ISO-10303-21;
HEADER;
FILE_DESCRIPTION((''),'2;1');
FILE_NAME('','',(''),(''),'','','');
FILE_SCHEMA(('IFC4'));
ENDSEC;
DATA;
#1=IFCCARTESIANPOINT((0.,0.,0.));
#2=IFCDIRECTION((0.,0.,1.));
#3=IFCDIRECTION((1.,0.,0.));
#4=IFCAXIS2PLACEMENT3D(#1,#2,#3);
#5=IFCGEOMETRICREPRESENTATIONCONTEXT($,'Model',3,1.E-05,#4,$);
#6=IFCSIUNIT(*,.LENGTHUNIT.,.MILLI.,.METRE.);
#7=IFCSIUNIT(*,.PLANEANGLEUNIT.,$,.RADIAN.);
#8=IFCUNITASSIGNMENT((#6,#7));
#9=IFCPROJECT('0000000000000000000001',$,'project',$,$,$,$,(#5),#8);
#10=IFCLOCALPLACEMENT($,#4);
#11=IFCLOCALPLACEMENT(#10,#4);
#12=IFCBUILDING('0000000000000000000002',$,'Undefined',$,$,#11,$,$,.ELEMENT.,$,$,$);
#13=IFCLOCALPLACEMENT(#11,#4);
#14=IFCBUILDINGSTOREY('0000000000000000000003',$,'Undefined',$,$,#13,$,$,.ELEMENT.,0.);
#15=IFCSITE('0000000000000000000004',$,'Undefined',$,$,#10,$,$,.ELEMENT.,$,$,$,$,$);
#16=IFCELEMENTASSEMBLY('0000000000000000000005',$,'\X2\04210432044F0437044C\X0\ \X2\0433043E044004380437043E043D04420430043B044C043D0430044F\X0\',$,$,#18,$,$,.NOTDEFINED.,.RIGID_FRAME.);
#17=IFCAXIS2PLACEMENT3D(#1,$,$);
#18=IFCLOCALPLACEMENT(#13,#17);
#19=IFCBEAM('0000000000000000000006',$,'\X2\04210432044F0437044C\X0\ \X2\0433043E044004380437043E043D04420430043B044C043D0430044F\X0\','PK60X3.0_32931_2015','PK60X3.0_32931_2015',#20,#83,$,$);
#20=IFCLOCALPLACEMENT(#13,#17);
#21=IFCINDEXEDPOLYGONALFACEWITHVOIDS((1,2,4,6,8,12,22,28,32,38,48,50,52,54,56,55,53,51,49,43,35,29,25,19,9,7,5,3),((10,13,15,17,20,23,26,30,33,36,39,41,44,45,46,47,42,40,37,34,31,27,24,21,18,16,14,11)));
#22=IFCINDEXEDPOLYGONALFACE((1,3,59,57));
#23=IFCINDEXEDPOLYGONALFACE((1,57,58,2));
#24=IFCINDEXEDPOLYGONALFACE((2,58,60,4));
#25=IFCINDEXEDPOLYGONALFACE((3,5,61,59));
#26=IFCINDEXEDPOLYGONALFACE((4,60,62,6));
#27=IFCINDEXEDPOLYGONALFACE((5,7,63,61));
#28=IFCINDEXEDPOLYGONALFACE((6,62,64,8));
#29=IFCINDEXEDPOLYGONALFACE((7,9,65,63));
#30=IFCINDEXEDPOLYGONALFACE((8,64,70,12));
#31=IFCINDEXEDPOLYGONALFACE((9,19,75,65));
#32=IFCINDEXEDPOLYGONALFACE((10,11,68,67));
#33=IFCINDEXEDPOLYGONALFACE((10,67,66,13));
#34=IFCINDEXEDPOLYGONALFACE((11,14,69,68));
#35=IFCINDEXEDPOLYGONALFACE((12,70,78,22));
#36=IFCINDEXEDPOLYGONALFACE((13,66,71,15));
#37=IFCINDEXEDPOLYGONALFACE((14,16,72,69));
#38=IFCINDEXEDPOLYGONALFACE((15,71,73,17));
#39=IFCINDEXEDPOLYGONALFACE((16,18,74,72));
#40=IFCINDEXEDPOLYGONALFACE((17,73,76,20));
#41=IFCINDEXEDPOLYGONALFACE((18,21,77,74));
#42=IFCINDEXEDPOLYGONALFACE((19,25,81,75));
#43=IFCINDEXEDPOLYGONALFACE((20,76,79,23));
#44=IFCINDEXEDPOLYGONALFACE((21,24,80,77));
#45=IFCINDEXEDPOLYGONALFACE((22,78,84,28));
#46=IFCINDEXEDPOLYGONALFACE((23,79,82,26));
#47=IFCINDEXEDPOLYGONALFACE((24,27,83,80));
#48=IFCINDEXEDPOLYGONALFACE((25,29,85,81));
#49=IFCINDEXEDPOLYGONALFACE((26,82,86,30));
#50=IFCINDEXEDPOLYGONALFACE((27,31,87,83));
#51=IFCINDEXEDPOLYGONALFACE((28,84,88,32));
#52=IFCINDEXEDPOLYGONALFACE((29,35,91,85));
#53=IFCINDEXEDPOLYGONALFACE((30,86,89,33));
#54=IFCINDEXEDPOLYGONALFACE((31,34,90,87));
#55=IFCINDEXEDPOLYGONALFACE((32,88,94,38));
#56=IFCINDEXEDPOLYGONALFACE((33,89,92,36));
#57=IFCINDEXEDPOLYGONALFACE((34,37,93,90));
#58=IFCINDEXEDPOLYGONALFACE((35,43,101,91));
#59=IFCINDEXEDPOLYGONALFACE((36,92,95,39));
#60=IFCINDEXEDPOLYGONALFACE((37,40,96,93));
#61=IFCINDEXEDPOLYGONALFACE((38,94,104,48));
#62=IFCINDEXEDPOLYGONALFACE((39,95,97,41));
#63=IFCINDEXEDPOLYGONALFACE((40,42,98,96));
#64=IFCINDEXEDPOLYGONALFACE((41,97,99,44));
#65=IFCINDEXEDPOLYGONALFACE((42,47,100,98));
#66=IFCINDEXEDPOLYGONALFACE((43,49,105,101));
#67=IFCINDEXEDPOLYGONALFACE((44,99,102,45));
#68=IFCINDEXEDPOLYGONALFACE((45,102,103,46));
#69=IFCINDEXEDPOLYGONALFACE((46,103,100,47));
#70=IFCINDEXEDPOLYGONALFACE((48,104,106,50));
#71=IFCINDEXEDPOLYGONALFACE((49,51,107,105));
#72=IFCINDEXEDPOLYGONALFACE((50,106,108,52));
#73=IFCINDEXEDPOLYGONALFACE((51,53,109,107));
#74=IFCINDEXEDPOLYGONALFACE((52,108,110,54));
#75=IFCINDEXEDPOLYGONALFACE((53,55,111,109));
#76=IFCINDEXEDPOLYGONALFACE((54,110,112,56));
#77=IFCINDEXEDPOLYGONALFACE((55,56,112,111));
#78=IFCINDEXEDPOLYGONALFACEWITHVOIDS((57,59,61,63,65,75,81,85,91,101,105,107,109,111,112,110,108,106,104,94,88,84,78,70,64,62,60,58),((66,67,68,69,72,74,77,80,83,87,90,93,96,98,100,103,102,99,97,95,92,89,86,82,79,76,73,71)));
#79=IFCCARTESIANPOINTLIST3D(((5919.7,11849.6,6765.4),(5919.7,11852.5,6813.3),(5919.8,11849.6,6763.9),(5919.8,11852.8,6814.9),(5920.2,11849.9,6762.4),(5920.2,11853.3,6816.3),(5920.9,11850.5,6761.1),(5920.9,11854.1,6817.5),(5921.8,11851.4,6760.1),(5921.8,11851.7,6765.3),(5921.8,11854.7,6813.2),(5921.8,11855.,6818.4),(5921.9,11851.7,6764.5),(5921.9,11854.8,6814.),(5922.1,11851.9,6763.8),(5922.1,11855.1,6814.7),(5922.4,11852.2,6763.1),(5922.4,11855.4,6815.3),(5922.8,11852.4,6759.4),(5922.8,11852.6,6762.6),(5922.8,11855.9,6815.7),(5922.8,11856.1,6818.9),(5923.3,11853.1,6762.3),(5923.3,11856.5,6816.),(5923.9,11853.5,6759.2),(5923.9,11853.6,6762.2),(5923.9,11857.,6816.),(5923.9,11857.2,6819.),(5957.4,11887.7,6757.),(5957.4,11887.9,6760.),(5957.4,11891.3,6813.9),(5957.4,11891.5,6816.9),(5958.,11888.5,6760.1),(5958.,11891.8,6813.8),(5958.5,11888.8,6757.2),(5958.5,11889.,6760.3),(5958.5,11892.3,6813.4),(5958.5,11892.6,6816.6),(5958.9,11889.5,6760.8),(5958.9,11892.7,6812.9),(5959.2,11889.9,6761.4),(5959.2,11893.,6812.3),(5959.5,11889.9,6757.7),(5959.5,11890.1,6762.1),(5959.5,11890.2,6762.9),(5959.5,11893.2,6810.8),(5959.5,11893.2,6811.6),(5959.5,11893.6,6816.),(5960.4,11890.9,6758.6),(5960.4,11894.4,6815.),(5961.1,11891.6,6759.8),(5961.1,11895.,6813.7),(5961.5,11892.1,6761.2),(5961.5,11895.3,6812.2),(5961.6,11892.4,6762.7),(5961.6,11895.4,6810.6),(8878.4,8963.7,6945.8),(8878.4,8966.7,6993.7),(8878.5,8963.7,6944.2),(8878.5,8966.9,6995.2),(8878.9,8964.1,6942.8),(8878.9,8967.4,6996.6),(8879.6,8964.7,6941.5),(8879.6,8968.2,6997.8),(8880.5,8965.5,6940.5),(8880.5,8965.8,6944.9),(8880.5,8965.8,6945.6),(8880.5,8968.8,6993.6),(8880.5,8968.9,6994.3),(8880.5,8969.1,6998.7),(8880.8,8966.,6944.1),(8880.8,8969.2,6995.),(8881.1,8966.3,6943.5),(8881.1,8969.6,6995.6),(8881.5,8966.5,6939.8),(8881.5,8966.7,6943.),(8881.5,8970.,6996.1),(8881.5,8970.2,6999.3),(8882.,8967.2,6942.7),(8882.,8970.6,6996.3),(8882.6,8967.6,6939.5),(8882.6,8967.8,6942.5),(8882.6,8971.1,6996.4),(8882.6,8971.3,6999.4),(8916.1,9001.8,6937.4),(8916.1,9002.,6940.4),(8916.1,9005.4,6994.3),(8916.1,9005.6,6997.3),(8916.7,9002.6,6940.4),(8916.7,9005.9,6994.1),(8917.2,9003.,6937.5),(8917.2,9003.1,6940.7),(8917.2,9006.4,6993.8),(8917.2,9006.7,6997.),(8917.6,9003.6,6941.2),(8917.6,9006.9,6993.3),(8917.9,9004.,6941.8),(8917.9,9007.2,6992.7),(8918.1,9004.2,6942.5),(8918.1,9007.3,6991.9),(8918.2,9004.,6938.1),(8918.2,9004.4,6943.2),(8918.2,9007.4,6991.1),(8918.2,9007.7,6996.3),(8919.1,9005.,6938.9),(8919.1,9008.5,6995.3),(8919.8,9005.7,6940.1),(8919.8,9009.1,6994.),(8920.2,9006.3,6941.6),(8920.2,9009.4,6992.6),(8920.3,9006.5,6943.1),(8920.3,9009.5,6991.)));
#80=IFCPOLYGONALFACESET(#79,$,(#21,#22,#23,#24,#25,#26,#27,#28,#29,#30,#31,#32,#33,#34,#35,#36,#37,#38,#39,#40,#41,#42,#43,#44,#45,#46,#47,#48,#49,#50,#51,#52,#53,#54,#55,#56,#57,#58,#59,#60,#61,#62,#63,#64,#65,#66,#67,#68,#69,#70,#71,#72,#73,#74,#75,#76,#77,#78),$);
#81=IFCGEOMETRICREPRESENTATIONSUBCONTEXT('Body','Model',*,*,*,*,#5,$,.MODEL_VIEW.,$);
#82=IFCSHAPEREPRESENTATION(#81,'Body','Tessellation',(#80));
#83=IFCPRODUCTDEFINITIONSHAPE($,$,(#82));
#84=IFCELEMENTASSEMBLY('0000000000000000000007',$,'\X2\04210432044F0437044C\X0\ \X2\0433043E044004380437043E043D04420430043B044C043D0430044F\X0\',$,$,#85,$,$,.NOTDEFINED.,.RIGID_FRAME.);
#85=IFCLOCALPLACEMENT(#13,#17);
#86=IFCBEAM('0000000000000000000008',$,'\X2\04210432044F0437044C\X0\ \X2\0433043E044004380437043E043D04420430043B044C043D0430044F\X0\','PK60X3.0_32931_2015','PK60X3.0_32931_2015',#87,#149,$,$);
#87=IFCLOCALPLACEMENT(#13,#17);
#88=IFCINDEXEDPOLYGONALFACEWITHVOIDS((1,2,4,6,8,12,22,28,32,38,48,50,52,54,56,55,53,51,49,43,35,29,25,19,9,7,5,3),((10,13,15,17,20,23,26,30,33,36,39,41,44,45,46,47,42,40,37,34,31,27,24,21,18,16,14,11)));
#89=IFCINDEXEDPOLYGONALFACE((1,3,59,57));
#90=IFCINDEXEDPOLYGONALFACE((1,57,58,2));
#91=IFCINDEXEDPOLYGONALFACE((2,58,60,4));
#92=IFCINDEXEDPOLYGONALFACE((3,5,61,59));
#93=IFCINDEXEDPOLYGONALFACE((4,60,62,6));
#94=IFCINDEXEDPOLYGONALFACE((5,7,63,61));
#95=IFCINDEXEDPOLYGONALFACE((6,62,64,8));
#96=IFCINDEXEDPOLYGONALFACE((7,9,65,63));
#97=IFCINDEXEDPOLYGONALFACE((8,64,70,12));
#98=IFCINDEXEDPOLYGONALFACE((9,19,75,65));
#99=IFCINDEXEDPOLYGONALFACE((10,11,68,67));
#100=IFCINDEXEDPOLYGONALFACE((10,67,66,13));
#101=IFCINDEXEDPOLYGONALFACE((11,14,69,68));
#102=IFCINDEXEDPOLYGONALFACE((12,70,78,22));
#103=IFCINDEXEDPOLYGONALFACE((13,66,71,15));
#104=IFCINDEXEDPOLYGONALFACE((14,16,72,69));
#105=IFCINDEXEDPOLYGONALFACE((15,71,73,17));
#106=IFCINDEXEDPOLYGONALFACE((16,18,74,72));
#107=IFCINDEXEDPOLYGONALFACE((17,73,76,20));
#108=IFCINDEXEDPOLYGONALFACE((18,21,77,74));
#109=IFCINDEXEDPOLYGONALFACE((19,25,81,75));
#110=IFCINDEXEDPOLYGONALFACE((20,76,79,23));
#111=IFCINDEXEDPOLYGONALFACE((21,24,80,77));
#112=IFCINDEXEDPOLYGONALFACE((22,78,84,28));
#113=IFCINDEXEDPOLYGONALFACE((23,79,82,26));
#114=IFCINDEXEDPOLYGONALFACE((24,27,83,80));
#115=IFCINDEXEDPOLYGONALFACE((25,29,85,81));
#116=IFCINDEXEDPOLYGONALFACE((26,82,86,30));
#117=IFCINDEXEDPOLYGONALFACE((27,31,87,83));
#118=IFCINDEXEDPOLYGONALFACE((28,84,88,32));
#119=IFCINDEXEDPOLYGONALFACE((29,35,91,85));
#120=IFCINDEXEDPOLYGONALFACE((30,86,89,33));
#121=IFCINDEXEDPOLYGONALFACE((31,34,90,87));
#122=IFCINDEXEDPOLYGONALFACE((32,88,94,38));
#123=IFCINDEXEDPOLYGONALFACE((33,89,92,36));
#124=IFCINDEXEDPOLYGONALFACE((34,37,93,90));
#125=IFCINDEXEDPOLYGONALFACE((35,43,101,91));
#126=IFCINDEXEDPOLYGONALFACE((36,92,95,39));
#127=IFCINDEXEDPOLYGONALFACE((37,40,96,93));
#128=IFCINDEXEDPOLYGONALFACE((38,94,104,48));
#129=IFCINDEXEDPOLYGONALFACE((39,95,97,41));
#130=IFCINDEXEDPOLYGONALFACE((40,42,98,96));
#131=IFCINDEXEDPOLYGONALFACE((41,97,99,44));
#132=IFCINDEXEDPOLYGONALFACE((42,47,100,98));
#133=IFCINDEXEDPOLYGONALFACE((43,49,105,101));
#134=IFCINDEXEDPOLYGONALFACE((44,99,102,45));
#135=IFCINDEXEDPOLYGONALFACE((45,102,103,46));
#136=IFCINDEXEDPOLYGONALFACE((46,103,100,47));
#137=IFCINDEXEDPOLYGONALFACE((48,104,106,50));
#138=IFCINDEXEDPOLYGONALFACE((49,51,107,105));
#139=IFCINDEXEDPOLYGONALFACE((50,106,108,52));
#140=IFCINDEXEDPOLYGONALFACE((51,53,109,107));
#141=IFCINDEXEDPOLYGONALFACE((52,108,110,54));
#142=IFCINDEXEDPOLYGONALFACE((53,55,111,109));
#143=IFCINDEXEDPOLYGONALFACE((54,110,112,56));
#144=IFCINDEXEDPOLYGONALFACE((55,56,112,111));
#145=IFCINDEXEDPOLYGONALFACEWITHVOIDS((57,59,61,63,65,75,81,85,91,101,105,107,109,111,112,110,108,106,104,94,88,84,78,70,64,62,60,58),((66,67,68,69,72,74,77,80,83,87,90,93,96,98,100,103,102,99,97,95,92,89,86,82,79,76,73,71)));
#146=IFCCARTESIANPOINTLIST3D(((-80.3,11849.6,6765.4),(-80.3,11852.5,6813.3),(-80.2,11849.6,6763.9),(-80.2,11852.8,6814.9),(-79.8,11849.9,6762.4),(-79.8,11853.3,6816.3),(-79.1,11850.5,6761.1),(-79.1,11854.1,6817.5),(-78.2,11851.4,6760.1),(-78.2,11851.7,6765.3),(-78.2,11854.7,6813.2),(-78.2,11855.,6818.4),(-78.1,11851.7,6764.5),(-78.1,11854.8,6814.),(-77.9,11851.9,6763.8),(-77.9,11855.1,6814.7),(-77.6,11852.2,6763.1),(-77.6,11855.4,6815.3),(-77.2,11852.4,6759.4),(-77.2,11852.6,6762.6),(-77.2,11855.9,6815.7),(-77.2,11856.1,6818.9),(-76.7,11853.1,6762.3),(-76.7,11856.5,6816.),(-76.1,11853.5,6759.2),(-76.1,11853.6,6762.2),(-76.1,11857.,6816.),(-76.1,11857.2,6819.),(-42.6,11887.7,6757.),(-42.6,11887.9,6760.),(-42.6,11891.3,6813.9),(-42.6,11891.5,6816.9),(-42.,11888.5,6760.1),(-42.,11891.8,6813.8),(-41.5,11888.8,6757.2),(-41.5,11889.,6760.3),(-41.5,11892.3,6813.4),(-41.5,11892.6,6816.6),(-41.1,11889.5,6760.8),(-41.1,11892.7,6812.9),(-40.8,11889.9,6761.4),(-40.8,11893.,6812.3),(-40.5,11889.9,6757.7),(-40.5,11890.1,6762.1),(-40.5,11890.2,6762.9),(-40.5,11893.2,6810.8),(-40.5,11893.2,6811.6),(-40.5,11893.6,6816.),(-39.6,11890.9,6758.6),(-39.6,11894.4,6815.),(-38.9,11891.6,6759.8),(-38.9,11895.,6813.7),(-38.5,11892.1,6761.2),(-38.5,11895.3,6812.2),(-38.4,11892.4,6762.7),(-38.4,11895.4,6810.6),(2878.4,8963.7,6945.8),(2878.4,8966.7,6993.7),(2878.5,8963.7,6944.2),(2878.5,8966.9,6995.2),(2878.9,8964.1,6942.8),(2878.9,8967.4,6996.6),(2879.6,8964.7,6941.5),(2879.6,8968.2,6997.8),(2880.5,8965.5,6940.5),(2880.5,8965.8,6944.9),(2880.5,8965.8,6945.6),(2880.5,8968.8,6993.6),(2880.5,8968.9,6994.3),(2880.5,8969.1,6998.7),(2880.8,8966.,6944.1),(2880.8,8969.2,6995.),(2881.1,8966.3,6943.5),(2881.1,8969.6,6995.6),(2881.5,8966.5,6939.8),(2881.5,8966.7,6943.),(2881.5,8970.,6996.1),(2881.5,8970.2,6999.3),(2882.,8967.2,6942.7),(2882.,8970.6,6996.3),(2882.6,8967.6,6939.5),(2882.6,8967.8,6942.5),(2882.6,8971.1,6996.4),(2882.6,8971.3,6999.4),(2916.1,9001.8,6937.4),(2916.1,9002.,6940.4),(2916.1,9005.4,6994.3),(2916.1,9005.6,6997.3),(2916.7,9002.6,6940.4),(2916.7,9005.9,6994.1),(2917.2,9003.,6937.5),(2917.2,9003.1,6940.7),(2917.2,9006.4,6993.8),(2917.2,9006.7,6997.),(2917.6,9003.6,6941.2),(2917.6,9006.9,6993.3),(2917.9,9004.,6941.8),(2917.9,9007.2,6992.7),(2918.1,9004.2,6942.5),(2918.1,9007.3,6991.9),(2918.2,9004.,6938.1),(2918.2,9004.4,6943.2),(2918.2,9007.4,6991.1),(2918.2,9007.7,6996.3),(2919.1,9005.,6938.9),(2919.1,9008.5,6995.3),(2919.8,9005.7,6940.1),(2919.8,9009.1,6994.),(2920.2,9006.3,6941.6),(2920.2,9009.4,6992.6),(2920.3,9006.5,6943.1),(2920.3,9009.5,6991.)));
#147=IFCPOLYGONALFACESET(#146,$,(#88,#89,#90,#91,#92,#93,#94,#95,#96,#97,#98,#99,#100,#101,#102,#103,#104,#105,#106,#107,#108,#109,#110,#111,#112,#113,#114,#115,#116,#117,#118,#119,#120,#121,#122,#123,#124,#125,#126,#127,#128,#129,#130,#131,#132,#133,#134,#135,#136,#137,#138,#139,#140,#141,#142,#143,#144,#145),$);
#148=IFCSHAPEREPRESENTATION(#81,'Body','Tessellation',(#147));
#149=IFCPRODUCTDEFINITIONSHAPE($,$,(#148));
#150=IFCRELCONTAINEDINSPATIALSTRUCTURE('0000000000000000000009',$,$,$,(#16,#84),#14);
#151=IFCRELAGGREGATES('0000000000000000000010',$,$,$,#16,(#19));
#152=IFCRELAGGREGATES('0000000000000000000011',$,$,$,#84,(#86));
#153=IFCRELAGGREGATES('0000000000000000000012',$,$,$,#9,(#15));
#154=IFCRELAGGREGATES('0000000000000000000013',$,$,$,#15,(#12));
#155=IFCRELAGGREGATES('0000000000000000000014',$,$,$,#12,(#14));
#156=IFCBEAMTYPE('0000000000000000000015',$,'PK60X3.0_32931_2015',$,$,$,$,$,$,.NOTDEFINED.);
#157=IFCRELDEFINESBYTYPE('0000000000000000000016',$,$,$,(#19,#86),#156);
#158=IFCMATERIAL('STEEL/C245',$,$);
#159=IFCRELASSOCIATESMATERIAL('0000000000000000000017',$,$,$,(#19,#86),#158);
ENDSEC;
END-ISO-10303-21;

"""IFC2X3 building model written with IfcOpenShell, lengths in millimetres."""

from ifc_helpers import new_model, si_unit, frame, origin_with_axes, origin_2d_with_axis, place, context, subcontext, project, spatial, hollow_rectangle, extrude, material, type_object, element, aggregate, save


model = new_model("IFC2X3")

# Units and contexts
model_context = context("Model", 3, precision=1e-05, world=origin_with_axes())
body_context = subcontext(model_context, "Body", "Model", "MODEL_VIEW")
ifc_project = project(units=[si_unit("LENGTHUNIT", "METRE", prefix="MILLI"), si_unit("PLANEANGLEUNIT", "RADIAN")], contexts=[model_context])

# Site, building, storey
site_placement = place(None, origin_with_axes())
site = spatial("IfcSite", under=ifc_project, at=site_placement, Name="Undefined", CompositionType="ELEMENT")
building_placement = place(site_placement, origin_with_axes())
building = spatial("IfcBuilding", under=site, at=building_placement, Name="Undefined", CompositionType="ELEMENT")
storey_placement = place(building_placement, origin_with_axes())
storey = spatial("IfcBuildingStorey", under=building, at=storey_placement, Name="Undefined", CompositionType="ELEMENT", Elevation=0.0)

# Shared definitions
ifc_material = material(Name="STEEL/C245")

# Element assemblies, beams
assembly_1_placement = place(storey_placement, origin_with_axes())
assembly_1 = element("IfcElementAssembly", 1, at=assembly_1_placement, inside=storey, Name="Связь горизонтальная", AssemblyPlace="NOTDEFINED", PredefinedType="RIGID_FRAME")
beam_type_1 = type_object("IfcBeamType", Name="PK60X3.0_32931_2015", PredefinedType="NOTDEFINED")
beam_1_placement = place(assembly_1_placement, frame((5940.7, 11872.5, 6788.0), z_axis=(0.0, 0.062378, 0.998053), x_axis=(0.715179, -0.69758, 0.043599)))
beam_1 = element("IfcBeam", 2, at=beam_1_placement, type_object=beam_type_1, material=ifc_material, Name="Связь горизонтальная", Description="PK60X3.0_32931_2015", ObjectType="PK60X3.0_32931_2015", context=body_context, shape_type="SweptSolid", body=[
    extrude(hollow_rectangle(XDim=60.0, YDim=60.0, WallThickness=3.0, InnerFilletRadius=3.0, OuterFilletRadius=6.0, at=origin_2d_with_axis()), frame((4137.0, 0.0, 0.0), z_axis=(-1.0, 0.0, 0.0), x_axis=(0.0, -1.0, 0.0)), (0.0, 0.0, 1.0), 4137.0),
])
aggregate(assembly_1, [beam_1])
assembly_2_placement = place(storey_placement, origin_with_axes())
assembly_2 = element("IfcElementAssembly", 3, at=assembly_2_placement, inside=storey, Name="Связь горизонтальная", AssemblyPlace="NOTDEFINED", PredefinedType="RIGID_FRAME")
beam_2_placement = place(assembly_2_placement, frame((-59.3, 11872.5, 6788.0), z_axis=(0.0, 0.062378, 0.998053), x_axis=(0.715179, -0.69758, 0.043599)))
beam_2 = element("IfcBeam", 4, at=beam_2_placement, type_object=beam_type_1, material=ifc_material, Name="Связь горизонтальная", Description="PK60X3.0_32931_2015", ObjectType="PK60X3.0_32931_2015", context=body_context, shape_type="SweptSolid", body=[
    extrude(hollow_rectangle(XDim=60.0, YDim=60.0, WallThickness=3.0, InnerFilletRadius=3.0, OuterFilletRadius=6.0, at=origin_2d_with_axis()), frame((4137.0, 0.0, 0.0), z_axis=(-1.0, 0.0, 0.0), x_axis=(0.0, -1.0, 0.0)), (0.0, 0.0, 1.0), 4137.0),
])
aggregate(assembly_2, [beam_2])

save(model, "model.ifc")
